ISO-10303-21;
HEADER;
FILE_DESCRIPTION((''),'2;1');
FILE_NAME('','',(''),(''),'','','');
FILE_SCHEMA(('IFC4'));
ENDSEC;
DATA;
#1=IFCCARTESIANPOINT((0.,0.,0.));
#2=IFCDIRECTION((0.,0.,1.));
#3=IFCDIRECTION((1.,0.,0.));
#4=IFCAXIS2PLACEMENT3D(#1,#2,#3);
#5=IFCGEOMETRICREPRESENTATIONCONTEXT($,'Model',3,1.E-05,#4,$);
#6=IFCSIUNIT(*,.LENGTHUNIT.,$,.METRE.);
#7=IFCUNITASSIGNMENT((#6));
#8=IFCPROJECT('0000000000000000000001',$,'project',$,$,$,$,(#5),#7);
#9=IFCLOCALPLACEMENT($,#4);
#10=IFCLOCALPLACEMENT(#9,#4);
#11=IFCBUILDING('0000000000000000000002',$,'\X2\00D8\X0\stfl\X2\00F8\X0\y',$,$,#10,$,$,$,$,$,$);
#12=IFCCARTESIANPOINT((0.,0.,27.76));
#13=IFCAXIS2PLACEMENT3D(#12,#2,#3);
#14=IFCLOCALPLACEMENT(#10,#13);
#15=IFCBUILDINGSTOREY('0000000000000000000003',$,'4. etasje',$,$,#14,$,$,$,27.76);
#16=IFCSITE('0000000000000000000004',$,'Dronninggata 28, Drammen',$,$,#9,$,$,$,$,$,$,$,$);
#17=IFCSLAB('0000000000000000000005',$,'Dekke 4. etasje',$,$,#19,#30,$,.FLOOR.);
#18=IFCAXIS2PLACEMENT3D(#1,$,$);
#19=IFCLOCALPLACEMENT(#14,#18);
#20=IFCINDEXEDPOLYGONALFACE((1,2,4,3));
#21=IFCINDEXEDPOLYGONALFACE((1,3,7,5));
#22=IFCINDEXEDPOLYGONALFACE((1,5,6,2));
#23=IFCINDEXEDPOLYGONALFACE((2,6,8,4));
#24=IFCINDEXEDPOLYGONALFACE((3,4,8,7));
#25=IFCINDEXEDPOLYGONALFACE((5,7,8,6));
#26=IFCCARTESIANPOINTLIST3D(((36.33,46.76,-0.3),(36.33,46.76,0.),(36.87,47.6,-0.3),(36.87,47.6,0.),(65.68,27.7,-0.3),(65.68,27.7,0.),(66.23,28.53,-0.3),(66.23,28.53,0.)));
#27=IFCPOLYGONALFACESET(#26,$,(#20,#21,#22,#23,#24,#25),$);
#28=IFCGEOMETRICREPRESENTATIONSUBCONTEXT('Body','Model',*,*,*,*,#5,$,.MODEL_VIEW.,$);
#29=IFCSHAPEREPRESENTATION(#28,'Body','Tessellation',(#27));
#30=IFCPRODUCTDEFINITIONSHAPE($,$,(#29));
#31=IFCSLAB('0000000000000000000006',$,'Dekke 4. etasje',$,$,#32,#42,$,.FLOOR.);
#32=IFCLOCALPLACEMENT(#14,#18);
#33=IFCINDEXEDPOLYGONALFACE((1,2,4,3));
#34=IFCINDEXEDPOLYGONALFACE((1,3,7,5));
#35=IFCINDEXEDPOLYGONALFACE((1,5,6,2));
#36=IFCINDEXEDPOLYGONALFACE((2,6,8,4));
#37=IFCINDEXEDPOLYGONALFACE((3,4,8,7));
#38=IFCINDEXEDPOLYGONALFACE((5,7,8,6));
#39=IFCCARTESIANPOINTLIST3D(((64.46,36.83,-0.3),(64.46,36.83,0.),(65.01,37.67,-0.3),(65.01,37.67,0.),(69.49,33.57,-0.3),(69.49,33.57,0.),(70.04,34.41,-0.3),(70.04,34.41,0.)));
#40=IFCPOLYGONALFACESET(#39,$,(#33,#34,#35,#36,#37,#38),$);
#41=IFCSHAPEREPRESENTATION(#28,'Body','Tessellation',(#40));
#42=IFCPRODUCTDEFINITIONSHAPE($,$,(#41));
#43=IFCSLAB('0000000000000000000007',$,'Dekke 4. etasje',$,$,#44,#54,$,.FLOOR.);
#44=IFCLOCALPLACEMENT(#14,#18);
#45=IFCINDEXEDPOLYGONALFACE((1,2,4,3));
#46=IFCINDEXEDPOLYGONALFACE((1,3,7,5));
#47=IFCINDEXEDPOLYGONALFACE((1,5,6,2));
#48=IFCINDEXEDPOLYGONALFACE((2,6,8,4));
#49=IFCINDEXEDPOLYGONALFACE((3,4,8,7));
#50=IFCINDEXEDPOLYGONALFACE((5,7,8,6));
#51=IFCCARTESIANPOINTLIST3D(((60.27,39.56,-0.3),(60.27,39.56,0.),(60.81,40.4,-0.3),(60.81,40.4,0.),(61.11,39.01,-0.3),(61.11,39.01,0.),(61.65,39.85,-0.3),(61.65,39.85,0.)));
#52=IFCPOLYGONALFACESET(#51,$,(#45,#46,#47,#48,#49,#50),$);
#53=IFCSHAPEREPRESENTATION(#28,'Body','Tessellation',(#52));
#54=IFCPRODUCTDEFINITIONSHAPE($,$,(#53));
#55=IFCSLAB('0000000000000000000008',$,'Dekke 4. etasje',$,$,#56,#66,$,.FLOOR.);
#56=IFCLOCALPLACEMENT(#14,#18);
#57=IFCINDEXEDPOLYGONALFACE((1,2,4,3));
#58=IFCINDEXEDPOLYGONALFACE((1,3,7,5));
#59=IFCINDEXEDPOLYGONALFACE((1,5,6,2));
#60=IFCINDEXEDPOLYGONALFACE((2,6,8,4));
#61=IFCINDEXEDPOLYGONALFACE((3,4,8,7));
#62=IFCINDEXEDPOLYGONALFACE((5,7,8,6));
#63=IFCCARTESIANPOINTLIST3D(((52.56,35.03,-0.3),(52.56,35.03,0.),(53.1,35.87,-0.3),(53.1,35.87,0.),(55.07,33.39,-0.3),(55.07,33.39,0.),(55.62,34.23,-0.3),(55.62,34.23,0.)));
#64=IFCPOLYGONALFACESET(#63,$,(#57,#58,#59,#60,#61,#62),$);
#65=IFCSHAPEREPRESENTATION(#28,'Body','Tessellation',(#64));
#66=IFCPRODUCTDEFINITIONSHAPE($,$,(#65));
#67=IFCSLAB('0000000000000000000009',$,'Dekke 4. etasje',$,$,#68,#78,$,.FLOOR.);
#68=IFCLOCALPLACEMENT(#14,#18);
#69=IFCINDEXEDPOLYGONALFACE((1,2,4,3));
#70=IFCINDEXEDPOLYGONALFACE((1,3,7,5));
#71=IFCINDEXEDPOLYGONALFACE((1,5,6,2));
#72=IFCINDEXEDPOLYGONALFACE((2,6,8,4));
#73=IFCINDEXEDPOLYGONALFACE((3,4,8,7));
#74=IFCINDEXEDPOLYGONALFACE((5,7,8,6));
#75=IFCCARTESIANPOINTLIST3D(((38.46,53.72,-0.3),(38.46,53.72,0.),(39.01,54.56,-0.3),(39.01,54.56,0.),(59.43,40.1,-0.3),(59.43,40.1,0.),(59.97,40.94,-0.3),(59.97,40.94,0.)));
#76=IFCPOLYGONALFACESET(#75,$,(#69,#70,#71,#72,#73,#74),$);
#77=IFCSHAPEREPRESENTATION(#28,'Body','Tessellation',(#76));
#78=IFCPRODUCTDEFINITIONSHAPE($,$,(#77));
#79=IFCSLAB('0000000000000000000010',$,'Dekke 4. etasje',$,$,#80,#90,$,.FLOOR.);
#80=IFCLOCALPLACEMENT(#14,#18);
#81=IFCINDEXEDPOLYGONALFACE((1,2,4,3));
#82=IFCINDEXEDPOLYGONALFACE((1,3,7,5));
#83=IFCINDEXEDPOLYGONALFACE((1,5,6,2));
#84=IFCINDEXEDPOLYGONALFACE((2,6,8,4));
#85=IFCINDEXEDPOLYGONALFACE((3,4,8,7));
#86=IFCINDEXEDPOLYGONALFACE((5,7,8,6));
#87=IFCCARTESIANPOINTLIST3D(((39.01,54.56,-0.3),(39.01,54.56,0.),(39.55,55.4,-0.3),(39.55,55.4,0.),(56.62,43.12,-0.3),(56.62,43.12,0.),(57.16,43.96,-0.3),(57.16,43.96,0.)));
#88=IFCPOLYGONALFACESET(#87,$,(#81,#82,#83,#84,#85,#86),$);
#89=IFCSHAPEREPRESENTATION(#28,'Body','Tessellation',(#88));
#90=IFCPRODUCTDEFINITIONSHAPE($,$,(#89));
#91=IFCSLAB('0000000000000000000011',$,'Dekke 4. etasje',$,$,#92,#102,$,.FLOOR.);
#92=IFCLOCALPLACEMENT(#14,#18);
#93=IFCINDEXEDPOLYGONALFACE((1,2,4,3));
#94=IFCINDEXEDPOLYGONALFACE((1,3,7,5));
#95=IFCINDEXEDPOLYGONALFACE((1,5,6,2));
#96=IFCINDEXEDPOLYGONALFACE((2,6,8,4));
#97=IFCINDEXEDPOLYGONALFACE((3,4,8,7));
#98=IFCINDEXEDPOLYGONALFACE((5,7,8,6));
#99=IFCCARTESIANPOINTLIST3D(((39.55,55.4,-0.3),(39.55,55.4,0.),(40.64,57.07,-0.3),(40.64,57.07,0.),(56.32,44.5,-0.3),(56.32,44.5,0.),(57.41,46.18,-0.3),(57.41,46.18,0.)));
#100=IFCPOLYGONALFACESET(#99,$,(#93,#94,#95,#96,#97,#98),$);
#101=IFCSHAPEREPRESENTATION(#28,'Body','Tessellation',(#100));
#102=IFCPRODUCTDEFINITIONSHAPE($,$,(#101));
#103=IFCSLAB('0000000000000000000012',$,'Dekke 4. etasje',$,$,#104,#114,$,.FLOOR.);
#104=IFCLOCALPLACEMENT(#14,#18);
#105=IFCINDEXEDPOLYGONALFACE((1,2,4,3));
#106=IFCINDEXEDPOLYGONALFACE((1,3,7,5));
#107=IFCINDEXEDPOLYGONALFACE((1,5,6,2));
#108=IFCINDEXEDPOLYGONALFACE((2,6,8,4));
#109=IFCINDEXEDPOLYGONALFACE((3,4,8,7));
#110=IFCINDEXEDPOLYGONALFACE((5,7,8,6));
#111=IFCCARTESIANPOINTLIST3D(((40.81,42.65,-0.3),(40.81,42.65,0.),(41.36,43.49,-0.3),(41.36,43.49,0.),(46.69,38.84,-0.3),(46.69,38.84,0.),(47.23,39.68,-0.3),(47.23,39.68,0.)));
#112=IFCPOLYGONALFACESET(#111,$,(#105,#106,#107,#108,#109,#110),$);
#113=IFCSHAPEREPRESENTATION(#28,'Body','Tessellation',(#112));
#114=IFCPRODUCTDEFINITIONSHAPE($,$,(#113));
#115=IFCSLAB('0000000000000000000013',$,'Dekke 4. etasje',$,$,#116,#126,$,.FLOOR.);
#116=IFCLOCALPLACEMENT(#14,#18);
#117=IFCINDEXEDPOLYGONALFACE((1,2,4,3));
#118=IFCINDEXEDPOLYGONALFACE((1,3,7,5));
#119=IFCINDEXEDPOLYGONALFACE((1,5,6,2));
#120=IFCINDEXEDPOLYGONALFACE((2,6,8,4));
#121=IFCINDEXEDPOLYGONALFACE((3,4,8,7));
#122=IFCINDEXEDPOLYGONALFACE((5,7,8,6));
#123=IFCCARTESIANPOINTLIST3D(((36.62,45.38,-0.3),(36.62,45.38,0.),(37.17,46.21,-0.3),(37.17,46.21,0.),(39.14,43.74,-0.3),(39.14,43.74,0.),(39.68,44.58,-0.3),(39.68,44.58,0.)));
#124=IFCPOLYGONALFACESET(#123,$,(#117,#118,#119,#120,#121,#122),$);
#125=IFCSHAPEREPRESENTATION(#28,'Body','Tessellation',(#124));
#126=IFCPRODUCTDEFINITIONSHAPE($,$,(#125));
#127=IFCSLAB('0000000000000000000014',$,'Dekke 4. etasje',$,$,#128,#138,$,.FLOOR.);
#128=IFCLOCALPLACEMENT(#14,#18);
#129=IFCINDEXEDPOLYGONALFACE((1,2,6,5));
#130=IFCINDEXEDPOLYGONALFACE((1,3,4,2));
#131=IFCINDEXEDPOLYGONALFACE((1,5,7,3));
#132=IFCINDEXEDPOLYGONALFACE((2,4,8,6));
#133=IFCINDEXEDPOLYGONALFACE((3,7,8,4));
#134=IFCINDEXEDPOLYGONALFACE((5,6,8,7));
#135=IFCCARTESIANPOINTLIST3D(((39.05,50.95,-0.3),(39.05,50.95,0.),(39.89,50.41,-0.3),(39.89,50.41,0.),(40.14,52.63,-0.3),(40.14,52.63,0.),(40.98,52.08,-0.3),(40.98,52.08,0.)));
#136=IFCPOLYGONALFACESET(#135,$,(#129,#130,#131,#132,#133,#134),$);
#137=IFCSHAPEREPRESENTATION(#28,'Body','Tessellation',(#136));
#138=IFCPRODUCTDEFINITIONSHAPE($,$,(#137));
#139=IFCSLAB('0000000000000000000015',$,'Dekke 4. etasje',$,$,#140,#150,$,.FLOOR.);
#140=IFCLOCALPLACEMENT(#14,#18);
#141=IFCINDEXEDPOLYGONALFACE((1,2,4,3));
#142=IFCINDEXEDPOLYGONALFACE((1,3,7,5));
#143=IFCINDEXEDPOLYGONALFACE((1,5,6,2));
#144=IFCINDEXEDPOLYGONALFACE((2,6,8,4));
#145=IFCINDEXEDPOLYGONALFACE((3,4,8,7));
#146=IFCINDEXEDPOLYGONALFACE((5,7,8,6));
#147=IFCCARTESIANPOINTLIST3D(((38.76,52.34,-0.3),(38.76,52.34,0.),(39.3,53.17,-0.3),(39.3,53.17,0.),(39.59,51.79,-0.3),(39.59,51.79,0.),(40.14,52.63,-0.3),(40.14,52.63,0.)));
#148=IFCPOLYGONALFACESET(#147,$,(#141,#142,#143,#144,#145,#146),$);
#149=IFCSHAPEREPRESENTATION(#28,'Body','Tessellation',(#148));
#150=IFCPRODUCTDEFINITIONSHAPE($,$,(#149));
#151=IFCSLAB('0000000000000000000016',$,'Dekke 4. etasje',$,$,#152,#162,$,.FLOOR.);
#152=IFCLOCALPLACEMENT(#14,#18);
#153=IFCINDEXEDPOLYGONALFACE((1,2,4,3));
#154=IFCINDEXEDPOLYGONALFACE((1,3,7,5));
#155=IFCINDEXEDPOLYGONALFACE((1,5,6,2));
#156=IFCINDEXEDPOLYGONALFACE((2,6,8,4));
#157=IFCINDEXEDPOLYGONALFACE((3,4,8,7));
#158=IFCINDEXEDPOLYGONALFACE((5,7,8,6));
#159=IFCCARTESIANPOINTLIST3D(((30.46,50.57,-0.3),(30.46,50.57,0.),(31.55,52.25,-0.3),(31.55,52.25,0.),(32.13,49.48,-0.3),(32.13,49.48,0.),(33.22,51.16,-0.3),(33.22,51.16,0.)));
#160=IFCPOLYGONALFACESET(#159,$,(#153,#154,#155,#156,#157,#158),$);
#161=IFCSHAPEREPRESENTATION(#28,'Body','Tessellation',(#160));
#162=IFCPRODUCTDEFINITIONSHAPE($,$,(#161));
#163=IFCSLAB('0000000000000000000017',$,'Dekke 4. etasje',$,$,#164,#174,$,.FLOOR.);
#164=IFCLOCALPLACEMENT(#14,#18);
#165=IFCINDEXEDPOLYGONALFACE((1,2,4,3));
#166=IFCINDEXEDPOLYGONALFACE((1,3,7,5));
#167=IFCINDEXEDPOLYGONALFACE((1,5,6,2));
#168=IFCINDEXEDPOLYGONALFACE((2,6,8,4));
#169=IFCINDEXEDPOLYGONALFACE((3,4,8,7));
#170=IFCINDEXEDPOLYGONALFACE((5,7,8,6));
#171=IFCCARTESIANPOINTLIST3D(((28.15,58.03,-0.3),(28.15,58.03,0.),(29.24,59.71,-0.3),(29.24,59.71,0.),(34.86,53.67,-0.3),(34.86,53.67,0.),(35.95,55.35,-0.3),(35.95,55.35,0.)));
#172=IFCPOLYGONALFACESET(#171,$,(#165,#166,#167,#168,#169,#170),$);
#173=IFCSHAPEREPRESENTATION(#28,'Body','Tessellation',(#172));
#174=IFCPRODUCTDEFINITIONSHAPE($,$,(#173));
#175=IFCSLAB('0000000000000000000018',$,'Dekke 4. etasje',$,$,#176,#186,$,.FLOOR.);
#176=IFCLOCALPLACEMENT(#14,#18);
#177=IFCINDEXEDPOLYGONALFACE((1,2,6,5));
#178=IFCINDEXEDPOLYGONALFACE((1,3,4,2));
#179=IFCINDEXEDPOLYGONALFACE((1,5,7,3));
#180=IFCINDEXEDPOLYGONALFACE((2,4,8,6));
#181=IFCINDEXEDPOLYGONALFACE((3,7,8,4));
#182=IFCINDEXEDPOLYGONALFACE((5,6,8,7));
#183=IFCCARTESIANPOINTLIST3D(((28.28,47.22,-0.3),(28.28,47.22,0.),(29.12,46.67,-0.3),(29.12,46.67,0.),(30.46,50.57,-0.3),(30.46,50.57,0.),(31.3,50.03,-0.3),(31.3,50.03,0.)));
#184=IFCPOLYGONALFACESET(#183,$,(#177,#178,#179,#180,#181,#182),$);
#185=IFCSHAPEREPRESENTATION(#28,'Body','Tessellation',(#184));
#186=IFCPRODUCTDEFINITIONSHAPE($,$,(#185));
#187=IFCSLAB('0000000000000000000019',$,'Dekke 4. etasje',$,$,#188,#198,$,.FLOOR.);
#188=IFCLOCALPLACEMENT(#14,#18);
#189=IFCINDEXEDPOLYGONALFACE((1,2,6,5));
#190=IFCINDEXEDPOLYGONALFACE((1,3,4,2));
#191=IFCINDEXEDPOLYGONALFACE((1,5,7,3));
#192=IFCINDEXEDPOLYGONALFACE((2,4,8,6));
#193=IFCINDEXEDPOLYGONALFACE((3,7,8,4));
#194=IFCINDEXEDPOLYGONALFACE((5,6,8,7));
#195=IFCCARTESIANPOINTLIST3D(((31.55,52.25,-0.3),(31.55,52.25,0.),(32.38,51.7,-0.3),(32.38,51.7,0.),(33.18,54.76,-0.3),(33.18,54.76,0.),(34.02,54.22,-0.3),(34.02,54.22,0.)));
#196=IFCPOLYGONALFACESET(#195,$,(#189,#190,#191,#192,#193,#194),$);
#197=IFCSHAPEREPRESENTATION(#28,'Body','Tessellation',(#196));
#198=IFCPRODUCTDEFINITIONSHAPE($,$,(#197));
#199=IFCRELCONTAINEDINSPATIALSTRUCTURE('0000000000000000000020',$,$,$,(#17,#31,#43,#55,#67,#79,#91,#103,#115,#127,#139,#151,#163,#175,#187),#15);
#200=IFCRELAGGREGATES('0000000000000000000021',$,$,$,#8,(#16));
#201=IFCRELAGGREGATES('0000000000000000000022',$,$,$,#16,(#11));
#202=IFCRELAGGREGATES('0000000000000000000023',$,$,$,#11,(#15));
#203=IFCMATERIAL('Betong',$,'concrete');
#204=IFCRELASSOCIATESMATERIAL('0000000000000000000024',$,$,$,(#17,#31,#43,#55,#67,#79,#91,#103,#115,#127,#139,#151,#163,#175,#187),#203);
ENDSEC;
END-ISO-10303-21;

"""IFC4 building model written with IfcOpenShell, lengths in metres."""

from ifc_helpers import new_model, si_unit, frame, origin_with_axes, place, context, subcontext, project, spatial, polyline, outline, extrude, material, element, save


model = new_model("IFC4")

# Units and contexts
model_context = context("Model", 3, precision=1e-05, world=origin_with_axes())
body_context = subcontext(model_context, "Body", "Model", "MODEL_VIEW")
ifc_project = project(units=[si_unit("LENGTHUNIT", "METRE")], contexts=[model_context])

# Site, building, storey
site_placement = place(None, origin_with_axes())
site = spatial("IfcSite", under=ifc_project, at=site_placement, Name="Dronninggata 28, Drammen")
building_placement = place(site_placement, origin_with_axes())
building = spatial("IfcBuilding", under=site, at=building_placement, Name="Østfløy")
storey_placement = place(building_placement, frame((0.0, 0.0, 27.76), z_axis=(0.0, 0.0, 1.0), x_axis=(1.0, 0.0, 0.0)))
storey = spatial("IfcBuildingStorey", under=building, at=storey_placement, Name="4. etasje", Elevation=27.76)

# Slabs
ifc_material = material(Name="Betong", Category="concrete")
slab_1_placement = place(storey_placement, frame((0.0, 0.0, -27.76), z_axis=(0.0, 0.0, 1.0), x_axis=(1.0, 0.0, 0.0)))
element("IfcSlab", 1, at=slab_1_placement, inside=storey, material=ifc_material, Name="Dekke 4. etasje", PredefinedType="FLOOR", context=body_context, shape_type="SweptSolid", body=[
    extrude(outline(polyline([(65.68, 27.7), (66.23, 28.53), (36.87, 47.6), (36.33, 46.76), (65.68, 27.7)])), frame((0.0, 0.0, 27.46)), (0.0, 0.0, 1.0), 0.3),
])
slab_2_placement = place(storey_placement, frame((0.0, 0.0, -27.76), z_axis=(0.0, 0.0, 1.0), x_axis=(1.0, 0.0, 0.0)))
element("IfcSlab", 2, at=slab_2_placement, inside=storey, material=ifc_material, Name="Dekke 4. etasje", PredefinedType="FLOOR", context=body_context, shape_type="SweptSolid", body=[
    extrude(outline(polyline([(69.49, 33.57), (70.04, 34.41), (65.01, 37.67), (64.46, 36.83), (69.49, 33.57)])), frame((0.0, 0.0, 27.46)), (0.0, 0.0, 1.0), 0.3),
])
slab_3_placement = place(storey_placement, frame((0.0, 0.0, -27.76), z_axis=(0.0, 0.0, 1.0), x_axis=(1.0, 0.0, 0.0)))
element("IfcSlab", 3, at=slab_3_placement, inside=storey, material=ifc_material, Name="Dekke 4. etasje", PredefinedType="FLOOR", context=body_context, shape_type="SweptSolid", body=[
    extrude(outline(polyline([(61.11, 39.01), (61.65, 39.85), (60.81, 40.4), (60.27, 39.56), (61.11, 39.01)])), frame((0.0, 0.0, 27.46)), (0.0, 0.0, 1.0), 0.3),
])
slab_4_placement = place(storey_placement, frame((0.0, 0.0, -27.76), z_axis=(0.0, 0.0, 1.0), x_axis=(1.0, 0.0, 0.0)))
element("IfcSlab", 4, at=slab_4_placement, inside=storey, material=ifc_material, Name="Dekke 4. etasje", PredefinedType="FLOOR", context=body_context, shape_type="SweptSolid", body=[
    extrude(outline(polyline([(55.07, 33.39), (55.62, 34.23), (53.1, 35.87), (52.56, 35.03), (55.07, 33.39)])), frame((0.0, 0.0, 27.46)), (0.0, 0.0, 1.0), 0.3),
])
slab_5_placement = place(storey_placement, frame((0.0, 0.0, -27.76), z_axis=(0.0, 0.0, 1.0), x_axis=(1.0, 0.0, 0.0)))
element("IfcSlab", 5, at=slab_5_placement, inside=storey, material=ifc_material, Name="Dekke 4. etasje", PredefinedType="FLOOR", context=body_context, shape_type="SweptSolid", body=[
    extrude(outline(polyline([(59.43, 40.1), (59.97, 40.94), (39.01, 54.56), (38.46, 53.72), (59.43, 40.1)])), frame((0.0, 0.0, 27.46)), (0.0, 0.0, 1.0), 0.3),
])
slab_6_placement = place(storey_placement, frame((0.0, 0.0, -27.76), z_axis=(0.0, 0.0, 1.0), x_axis=(1.0, 0.0, 0.0)))
element("IfcSlab", 6, at=slab_6_placement, inside=storey, material=ifc_material, Name="Dekke 4. etasje", PredefinedType="FLOOR", context=body_context, shape_type="SweptSolid", body=[
    extrude(outline(polyline([(56.62, 43.12), (57.16, 43.96), (39.55, 55.4), (39.01, 54.56), (56.62, 43.12)])), frame((0.0, 0.0, 27.46)), (0.0, 0.0, 1.0), 0.3),
])
slab_7_placement = place(storey_placement, frame((0.0, 0.0, -27.76), z_axis=(0.0, 0.0, 1.0), x_axis=(1.0, 0.0, 0.0)))
element("IfcSlab", 7, at=slab_7_placement, inside=storey, material=ifc_material, Name="Dekke 4. etasje", PredefinedType="FLOOR", context=body_context, shape_type="SweptSolid", body=[
    extrude(outline(polyline([(56.32, 44.5), (57.41, 46.18), (40.64, 57.07), (39.55, 55.4), (56.32, 44.5)])), frame((0.0, 0.0, 27.46)), (0.0, 0.0, 1.0), 0.3),
])
slab_8_placement = place(storey_placement, frame((0.0, 0.0, -27.76), z_axis=(0.0, 0.0, 1.0), x_axis=(1.0, 0.0, 0.0)))
element("IfcSlab", 8, at=slab_8_placement, inside=storey, material=ifc_material, Name="Dekke 4. etasje", PredefinedType="FLOOR", context=body_context, shape_type="SweptSolid", body=[
    extrude(outline(polyline([(46.69, 38.84), (47.23, 39.68), (41.36, 43.49), (40.81, 42.65), (46.69, 38.84)])), frame((0.0, 0.0, 27.46)), (0.0, 0.0, 1.0), 0.3),
])
slab_9_placement = place(storey_placement, frame((0.0, 0.0, -27.76), z_axis=(0.0, 0.0, 1.0), x_axis=(1.0, 0.0, 0.0)))
element("IfcSlab", 9, at=slab_9_placement, inside=storey, material=ifc_material, Name="Dekke 4. etasje", PredefinedType="FLOOR", context=body_context, shape_type="SweptSolid", body=[
    extrude(outline(polyline([(39.14, 43.74), (39.68, 44.58), (37.17, 46.21), (36.62, 45.38), (39.14, 43.74)])), frame((0.0, 0.0, 27.46)), (0.0, 0.0, 1.0), 0.3),
])
slab_10_placement = place(storey_placement, frame((0.0, 0.0, -27.76), z_axis=(0.0, 0.0, 1.0), x_axis=(1.0, 0.0, 0.0)))
element("IfcSlab", 10, at=slab_10_placement, inside=storey, material=ifc_material, Name="Dekke 4. etasje", PredefinedType="FLOOR", context=body_context, shape_type="SweptSolid", body=[
    extrude(outline(polyline([(39.89, 50.41), (40.98, 52.08), (40.14, 52.63), (39.05, 50.95), (39.89, 50.41)])), frame((0.0, 0.0, 27.46)), (0.0, 0.0, 1.0), 0.3),
])
slab_11_placement = place(storey_placement, frame((0.0, 0.0, -27.76), z_axis=(0.0, 0.0, 1.0), x_axis=(1.0, 0.0, 0.0)))
element("IfcSlab", 11, at=slab_11_placement, inside=storey, material=ifc_material, Name="Dekke 4. etasje", PredefinedType="FLOOR", context=body_context, shape_type="SweptSolid", body=[
    extrude(outline(polyline([(39.59, 51.79), (40.14, 52.63), (39.3, 53.17), (38.76, 52.34), (39.59, 51.79)])), frame((0.0, 0.0, 27.46)), (0.0, 0.0, 1.0), 0.3),
])
slab_12_placement = place(storey_placement, frame((0.0, 0.0, -27.76), z_axis=(0.0, 0.0, 1.0), x_axis=(1.0, 0.0, 0.0)))
element("IfcSlab", 12, at=slab_12_placement, inside=storey, material=ifc_material, Name="Dekke 4. etasje", PredefinedType="FLOOR", context=body_context, shape_type="SweptSolid", body=[
    extrude(outline(polyline([(32.13, 49.48), (33.22, 51.16), (31.55, 52.25), (30.46, 50.57), (32.13, 49.48)])), frame((0.0, 0.0, 27.46)), (0.0, 0.0, 1.0), 0.3),
])
slab_13_placement = place(storey_placement, frame((0.0, 0.0, -27.76), z_axis=(0.0, 0.0, 1.0), x_axis=(1.0, 0.0, 0.0)))
element("IfcSlab", 13, at=slab_13_placement, inside=storey, material=ifc_material, Name="Dekke 4. etasje", PredefinedType="FLOOR", context=body_context, shape_type="SweptSolid", body=[
    extrude(outline(polyline([(34.86, 53.67), (35.95, 55.35), (29.24, 59.71), (28.15, 58.03), (34.86, 53.67)])), frame((0.0, 0.0, 27.46)), (0.0, 0.0, 1.0), 0.3),
])
slab_14_placement = place(storey_placement, frame((0.0, 0.0, -27.76), z_axis=(0.0, 0.0, 1.0), x_axis=(1.0, 0.0, 0.0)))
element("IfcSlab", 14, at=slab_14_placement, inside=storey, material=ifc_material, Name="Dekke 4. etasje", PredefinedType="FLOOR", context=body_context, shape_type="SweptSolid", body=[
    extrude(outline(polyline([(29.12, 46.67), (31.3, 50.03), (30.46, 50.57), (28.28, 47.22), (29.12, 46.67)])), frame((0.0, 0.0, 27.46)), (0.0, 0.0, 1.0), 0.3),
])
slab_15_placement = place(storey_placement, frame((0.0, 0.0, -27.76), z_axis=(0.0, 0.0, 1.0), x_axis=(1.0, 0.0, 0.0)))
element("IfcSlab", 15, at=slab_15_placement, inside=storey, material=ifc_material, Name="Dekke 4. etasje", PredefinedType="FLOOR", context=body_context, shape_type="SweptSolid", body=[
    extrude(outline(polyline([(32.38, 51.7), (34.02, 54.22), (33.18, 54.76), (31.55, 52.25), (32.38, 51.7)])), frame((0.0, 0.0, 27.46)), (0.0, 0.0, 1.0), 0.3),
])

save(model, "model.ifc")
